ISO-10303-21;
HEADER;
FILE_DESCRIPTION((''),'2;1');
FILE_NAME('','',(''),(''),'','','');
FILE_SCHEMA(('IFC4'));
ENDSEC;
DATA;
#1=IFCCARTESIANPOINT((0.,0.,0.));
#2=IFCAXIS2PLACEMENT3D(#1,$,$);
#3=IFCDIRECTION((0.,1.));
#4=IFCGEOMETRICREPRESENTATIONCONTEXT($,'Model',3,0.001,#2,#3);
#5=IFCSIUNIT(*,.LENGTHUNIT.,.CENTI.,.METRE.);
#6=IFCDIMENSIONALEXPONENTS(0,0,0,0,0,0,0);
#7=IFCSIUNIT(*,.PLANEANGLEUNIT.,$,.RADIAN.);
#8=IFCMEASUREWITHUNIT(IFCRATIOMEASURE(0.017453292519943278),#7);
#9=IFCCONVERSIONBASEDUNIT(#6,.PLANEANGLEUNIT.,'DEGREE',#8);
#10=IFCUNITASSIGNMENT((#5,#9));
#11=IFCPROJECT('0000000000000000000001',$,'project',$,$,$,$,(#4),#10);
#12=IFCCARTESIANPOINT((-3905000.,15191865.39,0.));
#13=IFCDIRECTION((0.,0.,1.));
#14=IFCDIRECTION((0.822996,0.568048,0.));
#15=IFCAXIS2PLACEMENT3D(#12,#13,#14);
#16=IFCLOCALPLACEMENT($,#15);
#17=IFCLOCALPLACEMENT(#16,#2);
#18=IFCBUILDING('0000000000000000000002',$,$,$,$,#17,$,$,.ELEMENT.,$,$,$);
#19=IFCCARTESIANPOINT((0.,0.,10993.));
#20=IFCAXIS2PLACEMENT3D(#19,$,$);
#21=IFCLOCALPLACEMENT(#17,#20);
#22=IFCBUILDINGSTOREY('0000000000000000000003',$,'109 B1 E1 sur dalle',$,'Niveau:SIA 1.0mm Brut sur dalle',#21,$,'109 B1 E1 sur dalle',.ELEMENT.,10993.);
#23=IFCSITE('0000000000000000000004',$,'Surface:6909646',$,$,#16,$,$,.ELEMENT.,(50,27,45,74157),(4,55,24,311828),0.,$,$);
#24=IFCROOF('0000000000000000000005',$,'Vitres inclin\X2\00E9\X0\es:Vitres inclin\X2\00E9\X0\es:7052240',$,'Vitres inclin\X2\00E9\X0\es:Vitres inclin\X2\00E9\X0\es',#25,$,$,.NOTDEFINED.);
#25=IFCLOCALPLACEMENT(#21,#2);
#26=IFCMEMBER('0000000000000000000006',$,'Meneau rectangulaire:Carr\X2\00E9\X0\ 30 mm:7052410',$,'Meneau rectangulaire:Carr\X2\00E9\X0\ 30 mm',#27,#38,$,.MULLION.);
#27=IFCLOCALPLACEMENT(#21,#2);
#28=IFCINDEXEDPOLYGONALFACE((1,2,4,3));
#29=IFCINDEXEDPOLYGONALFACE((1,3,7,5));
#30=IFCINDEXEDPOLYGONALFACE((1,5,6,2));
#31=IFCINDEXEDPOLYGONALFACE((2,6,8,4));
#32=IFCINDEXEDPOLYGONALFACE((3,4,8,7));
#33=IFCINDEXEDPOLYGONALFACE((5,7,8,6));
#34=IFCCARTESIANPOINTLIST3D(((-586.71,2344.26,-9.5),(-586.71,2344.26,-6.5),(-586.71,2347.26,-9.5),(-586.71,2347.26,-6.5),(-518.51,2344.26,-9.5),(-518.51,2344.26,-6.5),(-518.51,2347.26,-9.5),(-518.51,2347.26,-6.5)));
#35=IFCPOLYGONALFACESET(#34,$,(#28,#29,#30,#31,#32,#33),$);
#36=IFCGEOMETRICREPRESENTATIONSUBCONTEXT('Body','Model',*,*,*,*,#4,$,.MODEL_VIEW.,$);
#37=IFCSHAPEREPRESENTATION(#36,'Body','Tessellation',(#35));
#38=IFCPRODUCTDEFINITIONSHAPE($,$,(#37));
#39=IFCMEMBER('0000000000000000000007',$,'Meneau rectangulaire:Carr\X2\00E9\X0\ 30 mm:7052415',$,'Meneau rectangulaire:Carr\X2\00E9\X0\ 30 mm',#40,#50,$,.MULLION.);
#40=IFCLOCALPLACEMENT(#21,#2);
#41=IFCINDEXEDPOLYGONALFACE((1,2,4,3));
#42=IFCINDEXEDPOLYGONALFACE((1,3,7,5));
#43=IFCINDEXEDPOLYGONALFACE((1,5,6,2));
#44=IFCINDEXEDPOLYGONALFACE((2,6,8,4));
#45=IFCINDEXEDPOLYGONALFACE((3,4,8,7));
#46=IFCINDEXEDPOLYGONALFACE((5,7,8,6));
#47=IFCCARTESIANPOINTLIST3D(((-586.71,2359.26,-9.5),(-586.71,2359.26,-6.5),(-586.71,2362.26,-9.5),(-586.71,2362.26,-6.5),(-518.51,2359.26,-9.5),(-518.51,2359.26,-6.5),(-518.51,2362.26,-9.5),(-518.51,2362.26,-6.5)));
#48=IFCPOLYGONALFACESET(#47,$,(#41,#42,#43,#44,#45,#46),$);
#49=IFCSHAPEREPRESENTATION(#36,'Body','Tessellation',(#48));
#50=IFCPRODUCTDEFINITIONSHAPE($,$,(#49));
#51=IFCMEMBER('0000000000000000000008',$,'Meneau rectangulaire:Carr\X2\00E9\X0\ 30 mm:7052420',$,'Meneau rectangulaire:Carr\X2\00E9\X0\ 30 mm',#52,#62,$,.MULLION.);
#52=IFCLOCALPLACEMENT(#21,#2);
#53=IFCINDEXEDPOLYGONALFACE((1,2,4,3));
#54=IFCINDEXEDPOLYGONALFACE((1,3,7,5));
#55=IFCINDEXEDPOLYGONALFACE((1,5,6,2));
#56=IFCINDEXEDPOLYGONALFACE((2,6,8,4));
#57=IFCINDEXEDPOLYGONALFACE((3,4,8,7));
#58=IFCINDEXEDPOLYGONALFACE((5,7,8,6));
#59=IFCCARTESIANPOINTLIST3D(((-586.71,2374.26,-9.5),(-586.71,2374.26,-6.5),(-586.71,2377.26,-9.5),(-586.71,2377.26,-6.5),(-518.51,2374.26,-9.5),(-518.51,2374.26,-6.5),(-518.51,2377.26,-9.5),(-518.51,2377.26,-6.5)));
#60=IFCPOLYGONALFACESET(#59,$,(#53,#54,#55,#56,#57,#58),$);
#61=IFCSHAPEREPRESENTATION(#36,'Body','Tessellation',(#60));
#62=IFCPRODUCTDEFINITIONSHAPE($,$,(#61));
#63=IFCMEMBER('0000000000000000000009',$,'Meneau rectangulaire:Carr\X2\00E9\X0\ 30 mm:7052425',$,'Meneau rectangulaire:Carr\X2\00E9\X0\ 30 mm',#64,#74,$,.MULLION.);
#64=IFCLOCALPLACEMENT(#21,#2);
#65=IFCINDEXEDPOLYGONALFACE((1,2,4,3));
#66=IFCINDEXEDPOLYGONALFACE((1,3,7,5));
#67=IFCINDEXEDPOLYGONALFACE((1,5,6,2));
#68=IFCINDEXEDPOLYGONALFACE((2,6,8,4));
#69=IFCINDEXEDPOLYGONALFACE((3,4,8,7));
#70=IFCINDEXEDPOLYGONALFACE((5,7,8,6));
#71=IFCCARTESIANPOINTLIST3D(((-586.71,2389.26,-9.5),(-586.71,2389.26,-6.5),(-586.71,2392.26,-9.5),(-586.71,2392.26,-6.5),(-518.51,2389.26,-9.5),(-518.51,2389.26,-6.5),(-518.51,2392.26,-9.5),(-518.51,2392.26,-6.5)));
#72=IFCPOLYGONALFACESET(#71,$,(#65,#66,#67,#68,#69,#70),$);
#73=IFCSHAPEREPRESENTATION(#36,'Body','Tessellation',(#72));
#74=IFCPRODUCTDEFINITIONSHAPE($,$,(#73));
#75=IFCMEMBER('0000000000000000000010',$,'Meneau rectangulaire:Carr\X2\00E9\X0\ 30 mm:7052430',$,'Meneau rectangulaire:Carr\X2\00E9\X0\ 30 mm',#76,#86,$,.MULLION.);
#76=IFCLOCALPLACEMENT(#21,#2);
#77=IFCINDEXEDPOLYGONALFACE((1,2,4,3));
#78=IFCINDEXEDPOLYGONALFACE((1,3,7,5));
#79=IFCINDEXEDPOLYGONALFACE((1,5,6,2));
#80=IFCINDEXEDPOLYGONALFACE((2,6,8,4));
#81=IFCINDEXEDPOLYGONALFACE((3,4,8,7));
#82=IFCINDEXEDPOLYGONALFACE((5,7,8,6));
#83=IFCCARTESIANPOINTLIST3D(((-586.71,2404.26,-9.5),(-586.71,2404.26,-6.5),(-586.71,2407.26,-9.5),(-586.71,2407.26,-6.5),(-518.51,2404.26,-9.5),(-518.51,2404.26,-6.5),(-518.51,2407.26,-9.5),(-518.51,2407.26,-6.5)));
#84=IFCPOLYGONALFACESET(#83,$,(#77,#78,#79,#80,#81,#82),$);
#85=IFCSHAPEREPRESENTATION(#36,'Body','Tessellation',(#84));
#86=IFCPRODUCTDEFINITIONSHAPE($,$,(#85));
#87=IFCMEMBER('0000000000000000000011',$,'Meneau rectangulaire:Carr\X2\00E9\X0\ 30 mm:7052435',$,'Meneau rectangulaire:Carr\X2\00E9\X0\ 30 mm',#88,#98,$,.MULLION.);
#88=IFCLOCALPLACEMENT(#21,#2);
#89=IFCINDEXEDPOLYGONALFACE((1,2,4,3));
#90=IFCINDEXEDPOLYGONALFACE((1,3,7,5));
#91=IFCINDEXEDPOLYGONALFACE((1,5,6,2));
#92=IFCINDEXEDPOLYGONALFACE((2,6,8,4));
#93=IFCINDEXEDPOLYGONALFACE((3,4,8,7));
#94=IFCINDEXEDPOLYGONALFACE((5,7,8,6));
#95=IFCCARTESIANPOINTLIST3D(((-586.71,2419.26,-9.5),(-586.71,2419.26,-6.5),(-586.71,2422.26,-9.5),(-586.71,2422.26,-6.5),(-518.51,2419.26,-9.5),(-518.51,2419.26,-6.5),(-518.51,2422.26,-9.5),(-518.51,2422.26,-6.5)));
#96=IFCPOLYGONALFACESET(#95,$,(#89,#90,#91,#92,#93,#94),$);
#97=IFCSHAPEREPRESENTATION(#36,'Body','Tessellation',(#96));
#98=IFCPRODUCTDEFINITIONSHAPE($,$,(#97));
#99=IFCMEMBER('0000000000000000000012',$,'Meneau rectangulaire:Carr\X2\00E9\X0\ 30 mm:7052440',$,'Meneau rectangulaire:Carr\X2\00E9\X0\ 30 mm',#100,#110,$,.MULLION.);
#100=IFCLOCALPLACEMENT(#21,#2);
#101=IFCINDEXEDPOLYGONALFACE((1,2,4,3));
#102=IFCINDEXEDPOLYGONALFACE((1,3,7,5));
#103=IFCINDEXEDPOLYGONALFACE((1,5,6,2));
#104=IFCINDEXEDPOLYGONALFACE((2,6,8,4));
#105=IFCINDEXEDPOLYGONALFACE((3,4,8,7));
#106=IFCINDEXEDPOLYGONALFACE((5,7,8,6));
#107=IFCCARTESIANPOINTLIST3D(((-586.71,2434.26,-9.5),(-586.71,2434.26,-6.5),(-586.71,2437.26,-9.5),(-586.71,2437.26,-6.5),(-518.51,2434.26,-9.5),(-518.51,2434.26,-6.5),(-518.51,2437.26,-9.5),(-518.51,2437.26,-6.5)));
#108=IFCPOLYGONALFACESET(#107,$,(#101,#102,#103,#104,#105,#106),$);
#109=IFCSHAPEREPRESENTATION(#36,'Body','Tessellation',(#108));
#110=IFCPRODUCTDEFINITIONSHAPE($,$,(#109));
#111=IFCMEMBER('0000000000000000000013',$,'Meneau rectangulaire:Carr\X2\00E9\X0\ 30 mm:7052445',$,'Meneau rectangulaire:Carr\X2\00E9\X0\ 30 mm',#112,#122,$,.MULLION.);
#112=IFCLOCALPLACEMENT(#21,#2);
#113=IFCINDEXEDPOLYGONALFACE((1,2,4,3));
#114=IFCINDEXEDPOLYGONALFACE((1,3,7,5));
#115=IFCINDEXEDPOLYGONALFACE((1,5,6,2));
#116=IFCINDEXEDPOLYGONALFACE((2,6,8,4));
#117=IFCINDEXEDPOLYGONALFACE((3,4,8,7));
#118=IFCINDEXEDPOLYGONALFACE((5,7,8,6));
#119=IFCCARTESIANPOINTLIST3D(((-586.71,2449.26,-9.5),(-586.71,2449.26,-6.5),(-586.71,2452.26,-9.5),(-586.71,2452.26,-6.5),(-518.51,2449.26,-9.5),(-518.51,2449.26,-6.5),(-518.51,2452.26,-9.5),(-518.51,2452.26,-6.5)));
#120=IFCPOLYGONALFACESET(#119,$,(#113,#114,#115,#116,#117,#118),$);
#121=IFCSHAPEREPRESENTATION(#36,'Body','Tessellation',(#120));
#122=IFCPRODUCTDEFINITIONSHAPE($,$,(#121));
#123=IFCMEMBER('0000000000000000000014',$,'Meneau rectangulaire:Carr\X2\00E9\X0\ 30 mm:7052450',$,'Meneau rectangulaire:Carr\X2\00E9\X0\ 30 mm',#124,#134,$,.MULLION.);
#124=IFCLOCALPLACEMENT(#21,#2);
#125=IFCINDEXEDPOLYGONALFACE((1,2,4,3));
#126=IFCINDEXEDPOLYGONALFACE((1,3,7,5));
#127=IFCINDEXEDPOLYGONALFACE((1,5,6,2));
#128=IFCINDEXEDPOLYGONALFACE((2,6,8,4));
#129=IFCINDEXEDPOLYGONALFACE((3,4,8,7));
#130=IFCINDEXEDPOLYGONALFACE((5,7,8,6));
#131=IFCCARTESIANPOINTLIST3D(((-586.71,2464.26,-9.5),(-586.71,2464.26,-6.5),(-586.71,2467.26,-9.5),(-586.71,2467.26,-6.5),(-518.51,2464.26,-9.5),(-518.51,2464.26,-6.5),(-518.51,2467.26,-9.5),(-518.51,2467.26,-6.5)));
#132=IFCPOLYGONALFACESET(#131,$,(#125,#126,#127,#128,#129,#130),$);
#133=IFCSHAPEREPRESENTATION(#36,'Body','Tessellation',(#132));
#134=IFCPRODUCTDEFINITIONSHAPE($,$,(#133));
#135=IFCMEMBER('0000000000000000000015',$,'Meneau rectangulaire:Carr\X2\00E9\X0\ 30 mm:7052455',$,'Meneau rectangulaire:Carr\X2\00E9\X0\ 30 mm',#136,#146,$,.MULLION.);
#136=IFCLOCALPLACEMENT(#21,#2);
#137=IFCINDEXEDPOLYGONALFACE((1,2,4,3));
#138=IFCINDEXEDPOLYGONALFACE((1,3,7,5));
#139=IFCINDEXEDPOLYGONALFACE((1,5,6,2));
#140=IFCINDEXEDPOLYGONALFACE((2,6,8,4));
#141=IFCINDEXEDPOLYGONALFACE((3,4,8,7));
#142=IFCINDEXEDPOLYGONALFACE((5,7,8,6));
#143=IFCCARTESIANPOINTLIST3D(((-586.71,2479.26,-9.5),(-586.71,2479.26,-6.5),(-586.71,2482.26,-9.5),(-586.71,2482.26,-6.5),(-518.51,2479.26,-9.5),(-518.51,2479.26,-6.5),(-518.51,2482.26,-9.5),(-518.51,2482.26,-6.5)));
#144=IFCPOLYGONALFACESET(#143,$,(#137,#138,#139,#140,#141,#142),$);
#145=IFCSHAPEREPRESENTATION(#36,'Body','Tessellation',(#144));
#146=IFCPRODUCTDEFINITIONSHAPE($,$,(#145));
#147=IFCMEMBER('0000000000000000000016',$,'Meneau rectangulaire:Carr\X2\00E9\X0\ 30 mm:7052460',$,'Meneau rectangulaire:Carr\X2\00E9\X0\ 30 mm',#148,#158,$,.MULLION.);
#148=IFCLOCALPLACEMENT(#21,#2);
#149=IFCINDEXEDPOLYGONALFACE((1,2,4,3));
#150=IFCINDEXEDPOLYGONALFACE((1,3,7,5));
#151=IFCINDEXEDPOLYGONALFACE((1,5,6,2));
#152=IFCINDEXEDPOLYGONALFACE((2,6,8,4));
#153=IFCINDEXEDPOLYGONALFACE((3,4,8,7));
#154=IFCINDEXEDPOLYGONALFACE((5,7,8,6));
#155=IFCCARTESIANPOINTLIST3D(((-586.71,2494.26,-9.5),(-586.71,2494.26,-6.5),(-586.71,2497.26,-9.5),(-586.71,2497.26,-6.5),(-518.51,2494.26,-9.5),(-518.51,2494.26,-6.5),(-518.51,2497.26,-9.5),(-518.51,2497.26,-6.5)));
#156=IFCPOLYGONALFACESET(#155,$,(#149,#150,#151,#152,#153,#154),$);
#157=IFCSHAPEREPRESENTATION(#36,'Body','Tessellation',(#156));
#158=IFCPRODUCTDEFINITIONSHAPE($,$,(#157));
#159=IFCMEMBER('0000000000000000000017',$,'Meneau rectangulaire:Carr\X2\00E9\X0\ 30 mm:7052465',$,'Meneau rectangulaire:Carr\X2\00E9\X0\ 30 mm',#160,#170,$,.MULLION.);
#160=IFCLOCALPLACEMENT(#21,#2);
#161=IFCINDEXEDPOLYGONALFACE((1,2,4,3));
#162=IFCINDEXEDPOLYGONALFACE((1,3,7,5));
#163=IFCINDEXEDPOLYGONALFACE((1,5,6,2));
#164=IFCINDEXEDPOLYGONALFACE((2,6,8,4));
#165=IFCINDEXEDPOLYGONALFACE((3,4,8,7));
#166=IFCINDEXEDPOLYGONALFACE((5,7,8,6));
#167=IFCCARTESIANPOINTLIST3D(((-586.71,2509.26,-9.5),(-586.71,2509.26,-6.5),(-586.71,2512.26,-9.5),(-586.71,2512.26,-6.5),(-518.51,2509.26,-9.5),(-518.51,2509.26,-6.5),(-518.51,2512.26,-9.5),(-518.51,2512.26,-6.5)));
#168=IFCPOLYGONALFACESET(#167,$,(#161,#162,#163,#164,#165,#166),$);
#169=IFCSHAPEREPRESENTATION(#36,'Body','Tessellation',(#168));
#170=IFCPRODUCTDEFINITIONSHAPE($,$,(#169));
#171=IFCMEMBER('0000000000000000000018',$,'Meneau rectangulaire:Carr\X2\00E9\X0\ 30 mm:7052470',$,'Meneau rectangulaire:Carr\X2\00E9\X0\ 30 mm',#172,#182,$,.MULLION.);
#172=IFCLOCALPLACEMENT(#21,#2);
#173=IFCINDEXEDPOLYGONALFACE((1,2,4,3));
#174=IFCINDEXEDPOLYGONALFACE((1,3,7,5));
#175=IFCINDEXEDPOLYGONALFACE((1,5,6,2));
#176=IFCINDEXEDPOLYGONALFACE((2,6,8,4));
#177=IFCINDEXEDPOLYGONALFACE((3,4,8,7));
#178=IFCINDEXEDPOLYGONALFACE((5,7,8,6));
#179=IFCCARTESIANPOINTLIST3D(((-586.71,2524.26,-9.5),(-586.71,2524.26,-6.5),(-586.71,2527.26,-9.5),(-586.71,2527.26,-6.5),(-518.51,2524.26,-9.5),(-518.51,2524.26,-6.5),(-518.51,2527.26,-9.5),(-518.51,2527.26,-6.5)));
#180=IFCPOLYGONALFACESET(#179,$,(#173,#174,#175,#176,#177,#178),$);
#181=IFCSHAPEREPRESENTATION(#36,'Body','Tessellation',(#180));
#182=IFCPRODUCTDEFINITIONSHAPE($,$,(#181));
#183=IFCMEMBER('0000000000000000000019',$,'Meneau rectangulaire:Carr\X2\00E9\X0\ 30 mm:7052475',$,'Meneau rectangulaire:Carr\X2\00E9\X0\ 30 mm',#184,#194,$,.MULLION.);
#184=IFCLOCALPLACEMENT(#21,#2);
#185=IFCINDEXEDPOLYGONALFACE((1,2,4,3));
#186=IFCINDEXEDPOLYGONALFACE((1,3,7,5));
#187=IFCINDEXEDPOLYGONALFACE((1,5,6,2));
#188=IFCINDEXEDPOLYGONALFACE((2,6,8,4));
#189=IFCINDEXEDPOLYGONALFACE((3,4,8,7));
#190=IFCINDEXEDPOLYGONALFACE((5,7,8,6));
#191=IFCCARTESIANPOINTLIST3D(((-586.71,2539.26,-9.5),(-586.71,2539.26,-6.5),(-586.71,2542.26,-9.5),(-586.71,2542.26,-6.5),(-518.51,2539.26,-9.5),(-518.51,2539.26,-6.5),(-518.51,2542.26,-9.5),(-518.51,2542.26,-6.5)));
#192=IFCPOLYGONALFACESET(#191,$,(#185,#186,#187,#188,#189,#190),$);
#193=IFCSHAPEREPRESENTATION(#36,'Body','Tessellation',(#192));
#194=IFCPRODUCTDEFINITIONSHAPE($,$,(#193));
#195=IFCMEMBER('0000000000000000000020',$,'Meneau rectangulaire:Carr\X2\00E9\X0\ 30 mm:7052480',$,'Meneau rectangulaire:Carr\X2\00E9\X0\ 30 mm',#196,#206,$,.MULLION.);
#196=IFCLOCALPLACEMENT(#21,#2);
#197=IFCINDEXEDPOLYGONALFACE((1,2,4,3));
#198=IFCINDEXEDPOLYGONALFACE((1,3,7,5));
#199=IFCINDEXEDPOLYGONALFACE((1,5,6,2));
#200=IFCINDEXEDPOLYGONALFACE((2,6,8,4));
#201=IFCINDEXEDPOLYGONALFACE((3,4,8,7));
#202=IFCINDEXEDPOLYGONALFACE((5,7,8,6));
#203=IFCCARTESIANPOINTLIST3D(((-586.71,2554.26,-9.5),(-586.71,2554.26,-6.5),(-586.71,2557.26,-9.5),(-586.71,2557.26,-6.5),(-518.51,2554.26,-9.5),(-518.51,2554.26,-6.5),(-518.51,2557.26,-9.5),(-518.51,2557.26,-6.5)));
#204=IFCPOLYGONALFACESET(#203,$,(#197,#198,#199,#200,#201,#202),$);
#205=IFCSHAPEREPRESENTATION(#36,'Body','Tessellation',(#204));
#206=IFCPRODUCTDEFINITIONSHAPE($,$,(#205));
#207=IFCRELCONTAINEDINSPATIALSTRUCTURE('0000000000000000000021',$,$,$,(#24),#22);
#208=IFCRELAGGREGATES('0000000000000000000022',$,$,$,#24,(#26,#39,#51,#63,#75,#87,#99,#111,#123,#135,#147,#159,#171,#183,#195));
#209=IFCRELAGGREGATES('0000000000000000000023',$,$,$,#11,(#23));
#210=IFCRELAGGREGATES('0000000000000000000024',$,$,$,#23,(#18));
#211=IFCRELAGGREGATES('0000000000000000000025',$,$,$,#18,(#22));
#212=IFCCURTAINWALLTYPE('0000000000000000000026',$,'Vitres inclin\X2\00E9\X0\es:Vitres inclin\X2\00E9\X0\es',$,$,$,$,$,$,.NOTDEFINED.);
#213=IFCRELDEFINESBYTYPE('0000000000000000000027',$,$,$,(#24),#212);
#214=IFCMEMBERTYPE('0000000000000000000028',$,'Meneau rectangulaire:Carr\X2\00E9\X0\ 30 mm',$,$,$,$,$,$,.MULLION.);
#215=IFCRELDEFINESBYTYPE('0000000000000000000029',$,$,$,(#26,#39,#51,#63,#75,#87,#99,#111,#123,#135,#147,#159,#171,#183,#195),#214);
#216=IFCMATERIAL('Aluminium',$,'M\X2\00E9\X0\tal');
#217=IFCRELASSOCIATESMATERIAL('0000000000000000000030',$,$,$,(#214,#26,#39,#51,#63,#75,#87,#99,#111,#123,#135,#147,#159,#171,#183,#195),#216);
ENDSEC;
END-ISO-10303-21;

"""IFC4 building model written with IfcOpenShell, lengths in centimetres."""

from ifc_helpers import new_model, entity, si_unit, converted_unit, direction, frame, origin, place, context, subcontext, project, spatial, indexed_curve, outline, extrude, source, transform, mapped, material, type_object, type_shapes, element, aggregate, save


model = new_model("IFC4")

# Units and contexts
model_context = context("Model", 3, precision=0.001, world=origin(), true_north=direction((0.0, 1.0)))
body_context = subcontext(model_context, "Body", "Model", "MODEL_VIEW")
ifc_project = project(units=[si_unit("LENGTHUNIT", "METRE", prefix="CENTI"), converted_unit("PLANEANGLEUNIT", "DEGREE", entity("IfcRatioMeasure", 0.017453292519943278), si_unit("PLANEANGLEUNIT", "RADIAN"), dimensions=[0, 0, 0, 0, 0, 0, 0])], contexts=[model_context])

# Site, building, storey
site_placement = place(None, frame((-3905000.0, 15191865.39, 0.0), z_axis=(0.0, 0.0, 1.0), x_axis=(0.822996, 0.568048, 0.0)))
site = spatial("IfcSite", under=ifc_project, at=site_placement, Name="Surface:6909646", CompositionType="ELEMENT", RefLatitude=(50, 27, 45, 74157), RefLongitude=(4, 55, 24, 311828), RefElevation=0.0)
building_placement = place(site_placement, origin())
building = spatial("IfcBuilding", under=site, at=building_placement, CompositionType="ELEMENT")
storey_placement = place(building_placement, frame((0.0, 0.0, 10993.0)))
storey = spatial("IfcBuildingStorey", under=building, at=storey_placement, Name="109 B1 E1 sur dalle", ObjectType="Niveau:SIA 1.0mm Brut sur dalle", LongName="109 B1 E1 sur dalle", CompositionType="ELEMENT", Elevation=10993.0)

# Roof, members
curtain_wall_type = type_object("IfcCurtainWallType", Name="Vitres inclinées:Vitres inclinées", PredefinedType="NOTDEFINED")
roof_placement = place(storey_placement, frame((0.0, 0.0, -10993.0)))
roof = element("IfcRoof", 1, at=roof_placement, inside=storey, type_object=curtain_wall_type, Name="Vitres inclinées:Vitres inclinées:7052240", ObjectType="Vitres inclinées:Vitres inclinées", PredefinedType="NOTDEFINED")
ifc_material = material(Name="Aluminium", Category="Métal")
member_type_1 = type_object("IfcMemberType", Name="Meneau rectangulaire:Carré 30 mm", PredefinedType="MULLION", material=ifc_material)
shared_shape_1 = source(origin(), body_context, "Body", "SweptSolid", [
    extrude(outline(indexed_curve([(-1.5, -1.5), (1.5, -1.5), (1.5, 1.5), (-1.5, 1.5), (-1.5, -1.5)], self_intersect=False)), frame((0.0, 0.0, -68.2), z_axis=(0.0, 0.0, 1.0), x_axis=(0.0, -1.0, 0.0)), (0.0, 0.0, 1.0), 68.2),
])
type_shapes(member_type_1, [shared_shape_1])
member_1_placement = place(roof_placement, frame((-586.71, 2345.76, 10985.0), z_axis=(-1.0, 0.0, 0.0), x_axis=(0.0, 1.0, 0.0)))
member_1 = element("IfcMember", 2, at=member_1_placement, type_object=member_type_1, material=ifc_material, Name="Meneau rectangulaire:Carré 30 mm:7052410", ObjectType="Meneau rectangulaire:Carré 30 mm", PredefinedType="MULLION", context=body_context, shape_type="MappedRepresentation", body=[
    mapped(shared_shape_1, transform((0.0, 0.0, 0.0), scale=1.0)),
])
member_2_placement = place(roof_placement, frame((-586.71, 2360.76, 10985.0), z_axis=(-1.0, 0.0, 0.0), x_axis=(0.0, 1.0, 0.0)))
member_2 = element("IfcMember", 3, at=member_2_placement, type_object=member_type_1, material=ifc_material, Name="Meneau rectangulaire:Carré 30 mm:7052415", ObjectType="Meneau rectangulaire:Carré 30 mm", PredefinedType="MULLION", context=body_context, shape_type="MappedRepresentation", body=[
    mapped(shared_shape_1, transform((0.0, 0.0, 0.0), scale=1.0)),
])
member_3_placement = place(roof_placement, frame((-586.71, 2375.76, 10985.0), z_axis=(-1.0, 0.0, 0.0), x_axis=(0.0, 1.0, 0.0)))
member_3 = element("IfcMember", 4, at=member_3_placement, type_object=member_type_1, material=ifc_material, Name="Meneau rectangulaire:Carré 30 mm:7052420", ObjectType="Meneau rectangulaire:Carré 30 mm", PredefinedType="MULLION", context=body_context, shape_type="MappedRepresentation", body=[
    mapped(shared_shape_1, transform((0.0, 0.0, 0.0), scale=1.0)),
])
member_4_placement = place(roof_placement, frame((-586.71, 2390.76, 10985.0), z_axis=(-1.0, 0.0, 0.0), x_axis=(0.0, 1.0, 0.0)))
member_4 = element("IfcMember", 5, at=member_4_placement, type_object=member_type_1, material=ifc_material, Name="Meneau rectangulaire:Carré 30 mm:7052425", ObjectType="Meneau rectangulaire:Carré 30 mm", PredefinedType="MULLION", context=body_context, shape_type="MappedRepresentation", body=[
    mapped(shared_shape_1, transform((0.0, 0.0, 0.0), scale=1.0)),
])
member_5_placement = place(roof_placement, frame((-586.71, 2405.76, 10985.0), z_axis=(-1.0, 0.0, 0.0), x_axis=(0.0, 1.0, 0.0)))
member_5 = element("IfcMember", 6, at=member_5_placement, type_object=member_type_1, material=ifc_material, Name="Meneau rectangulaire:Carré 30 mm:7052430", ObjectType="Meneau rectangulaire:Carré 30 mm", PredefinedType="MULLION", context=body_context, shape_type="MappedRepresentation", body=[
    mapped(shared_shape_1, transform((0.0, 0.0, 0.0), scale=1.0)),
])
member_6_placement = place(roof_placement, frame((-586.71, 2420.76, 10985.0), z_axis=(-1.0, 0.0, 0.0), x_axis=(0.0, 1.0, 0.0)))
member_6 = element("IfcMember", 7, at=member_6_placement, type_object=member_type_1, material=ifc_material, Name="Meneau rectangulaire:Carré 30 mm:7052435", ObjectType="Meneau rectangulaire:Carré 30 mm", PredefinedType="MULLION", context=body_context, shape_type="MappedRepresentation", body=[
    mapped(shared_shape_1, transform((0.0, 0.0, 0.0), scale=1.0)),
])
member_7_placement = place(roof_placement, frame((-586.71, 2435.76, 10985.0), z_axis=(-1.0, 0.0, 0.0), x_axis=(0.0, 1.0, 0.0)))
member_7 = element("IfcMember", 8, at=member_7_placement, type_object=member_type_1, material=ifc_material, Name="Meneau rectangulaire:Carré 30 mm:7052440", ObjectType="Meneau rectangulaire:Carré 30 mm", PredefinedType="MULLION", context=body_context, shape_type="MappedRepresentation", body=[
    mapped(shared_shape_1, transform((0.0, 0.0, 0.0), scale=1.0)),
])
member_8_placement = place(roof_placement, frame((-586.71, 2450.76, 10985.0), z_axis=(-1.0, 0.0, 0.0), x_axis=(0.0, 1.0, 0.0)))
member_8 = element("IfcMember", 9, at=member_8_placement, type_object=member_type_1, material=ifc_material, Name="Meneau rectangulaire:Carré 30 mm:7052445", ObjectType="Meneau rectangulaire:Carré 30 mm", PredefinedType="MULLION", context=body_context, shape_type="MappedRepresentation", body=[
    mapped(shared_shape_1, transform((0.0, 0.0, 0.0), scale=1.0)),
])
member_9_placement = place(roof_placement, frame((-586.71, 2465.76, 10985.0), z_axis=(-1.0, 0.0, 0.0), x_axis=(0.0, 1.0, 0.0)))
member_9 = element("IfcMember", 10, at=member_9_placement, type_object=member_type_1, material=ifc_material, Name="Meneau rectangulaire:Carré 30 mm:7052450", ObjectType="Meneau rectangulaire:Carré 30 mm", PredefinedType="MULLION", context=body_context, shape_type="MappedRepresentation", body=[
    mapped(shared_shape_1, transform((0.0, 0.0, 0.0), scale=1.0)),
])
member_10_placement = place(roof_placement, frame((-586.71, 2480.76, 10985.0), z_axis=(-1.0, 0.0, 0.0), x_axis=(0.0, 1.0, 0.0)))
member_10 = element("IfcMember", 11, at=member_10_placement, type_object=member_type_1, material=ifc_material, Name="Meneau rectangulaire:Carré 30 mm:7052455", ObjectType="Meneau rectangulaire:Carré 30 mm", PredefinedType="MULLION", context=body_context, shape_type="MappedRepresentation", body=[
    mapped(shared_shape_1, transform((0.0, 0.0, 0.0), scale=1.0)),
])
member_11_placement = place(roof_placement, frame((-586.71, 2495.76, 10985.0), z_axis=(-1.0, 0.0, 0.0), x_axis=(0.0, 1.0, 0.0)))
member_11 = element("IfcMember", 12, at=member_11_placement, type_object=member_type_1, material=ifc_material, Name="Meneau rectangulaire:Carré 30 mm:7052460", ObjectType="Meneau rectangulaire:Carré 30 mm", PredefinedType="MULLION", context=body_context, shape_type="MappedRepresentation", body=[
    mapped(shared_shape_1, transform((0.0, 0.0, 0.0), scale=1.0)),
])
member_12_placement = place(roof_placement, frame((-586.71, 2510.76, 10985.0), z_axis=(-1.0, 0.0, 0.0), x_axis=(0.0, 1.0, 0.0)))
member_12 = element("IfcMember", 13, at=member_12_placement, type_object=member_type_1, material=ifc_material, Name="Meneau rectangulaire:Carré 30 mm:7052465", ObjectType="Meneau rectangulaire:Carré 30 mm", PredefinedType="MULLION", context=body_context, shape_type="MappedRepresentation", body=[
    mapped(shared_shape_1, transform((0.0, 0.0, 0.0), scale=1.0)),
])
member_13_placement = place(roof_placement, frame((-586.71, 2525.76, 10985.0), z_axis=(-1.0, 0.0, 0.0), x_axis=(0.0, 1.0, 0.0)))
member_13 = element("IfcMember", 14, at=member_13_placement, type_object=member_type_1, material=ifc_material, Name="Meneau rectangulaire:Carré 30 mm:7052470", ObjectType="Meneau rectangulaire:Carré 30 mm", PredefinedType="MULLION", context=body_context, shape_type="MappedRepresentation", body=[
    mapped(shared_shape_1, transform((0.0, 0.0, 0.0), scale=1.0)),
])
member_14_placement = place(roof_placement, frame((-586.71, 2540.76, 10985.0), z_axis=(-1.0, 0.0, 0.0), x_axis=(0.0, 1.0, 0.0)))
member_14 = element("IfcMember", 15, at=member_14_placement, type_object=member_type_1, material=ifc_material, Name="Meneau rectangulaire:Carré 30 mm:7052475", ObjectType="Meneau rectangulaire:Carré 30 mm", PredefinedType="MULLION", context=body_context, shape_type="MappedRepresentation", body=[
    mapped(shared_shape_1, transform((0.0, 0.0, 0.0), scale=1.0)),
])
member_15_placement = place(roof_placement, frame((-586.71, 2555.76, 10985.0), z_axis=(-1.0, 0.0, 0.0), x_axis=(0.0, 1.0, 0.0)))
member_15 = element("IfcMember", 16, at=member_15_placement, type_object=member_type_1, material=ifc_material, Name="Meneau rectangulaire:Carré 30 mm:7052480", ObjectType="Meneau rectangulaire:Carré 30 mm", PredefinedType="MULLION", context=body_context, shape_type="MappedRepresentation", body=[
    mapped(shared_shape_1, transform((0.0, 0.0, 0.0), scale=1.0)),
])
aggregate(roof, [member_1, member_2, member_3, member_4, member_5, member_6, member_7, member_8, member_9, member_10, member_11, member_12, member_13, member_14, member_15])

save(model, "model.ifc")
